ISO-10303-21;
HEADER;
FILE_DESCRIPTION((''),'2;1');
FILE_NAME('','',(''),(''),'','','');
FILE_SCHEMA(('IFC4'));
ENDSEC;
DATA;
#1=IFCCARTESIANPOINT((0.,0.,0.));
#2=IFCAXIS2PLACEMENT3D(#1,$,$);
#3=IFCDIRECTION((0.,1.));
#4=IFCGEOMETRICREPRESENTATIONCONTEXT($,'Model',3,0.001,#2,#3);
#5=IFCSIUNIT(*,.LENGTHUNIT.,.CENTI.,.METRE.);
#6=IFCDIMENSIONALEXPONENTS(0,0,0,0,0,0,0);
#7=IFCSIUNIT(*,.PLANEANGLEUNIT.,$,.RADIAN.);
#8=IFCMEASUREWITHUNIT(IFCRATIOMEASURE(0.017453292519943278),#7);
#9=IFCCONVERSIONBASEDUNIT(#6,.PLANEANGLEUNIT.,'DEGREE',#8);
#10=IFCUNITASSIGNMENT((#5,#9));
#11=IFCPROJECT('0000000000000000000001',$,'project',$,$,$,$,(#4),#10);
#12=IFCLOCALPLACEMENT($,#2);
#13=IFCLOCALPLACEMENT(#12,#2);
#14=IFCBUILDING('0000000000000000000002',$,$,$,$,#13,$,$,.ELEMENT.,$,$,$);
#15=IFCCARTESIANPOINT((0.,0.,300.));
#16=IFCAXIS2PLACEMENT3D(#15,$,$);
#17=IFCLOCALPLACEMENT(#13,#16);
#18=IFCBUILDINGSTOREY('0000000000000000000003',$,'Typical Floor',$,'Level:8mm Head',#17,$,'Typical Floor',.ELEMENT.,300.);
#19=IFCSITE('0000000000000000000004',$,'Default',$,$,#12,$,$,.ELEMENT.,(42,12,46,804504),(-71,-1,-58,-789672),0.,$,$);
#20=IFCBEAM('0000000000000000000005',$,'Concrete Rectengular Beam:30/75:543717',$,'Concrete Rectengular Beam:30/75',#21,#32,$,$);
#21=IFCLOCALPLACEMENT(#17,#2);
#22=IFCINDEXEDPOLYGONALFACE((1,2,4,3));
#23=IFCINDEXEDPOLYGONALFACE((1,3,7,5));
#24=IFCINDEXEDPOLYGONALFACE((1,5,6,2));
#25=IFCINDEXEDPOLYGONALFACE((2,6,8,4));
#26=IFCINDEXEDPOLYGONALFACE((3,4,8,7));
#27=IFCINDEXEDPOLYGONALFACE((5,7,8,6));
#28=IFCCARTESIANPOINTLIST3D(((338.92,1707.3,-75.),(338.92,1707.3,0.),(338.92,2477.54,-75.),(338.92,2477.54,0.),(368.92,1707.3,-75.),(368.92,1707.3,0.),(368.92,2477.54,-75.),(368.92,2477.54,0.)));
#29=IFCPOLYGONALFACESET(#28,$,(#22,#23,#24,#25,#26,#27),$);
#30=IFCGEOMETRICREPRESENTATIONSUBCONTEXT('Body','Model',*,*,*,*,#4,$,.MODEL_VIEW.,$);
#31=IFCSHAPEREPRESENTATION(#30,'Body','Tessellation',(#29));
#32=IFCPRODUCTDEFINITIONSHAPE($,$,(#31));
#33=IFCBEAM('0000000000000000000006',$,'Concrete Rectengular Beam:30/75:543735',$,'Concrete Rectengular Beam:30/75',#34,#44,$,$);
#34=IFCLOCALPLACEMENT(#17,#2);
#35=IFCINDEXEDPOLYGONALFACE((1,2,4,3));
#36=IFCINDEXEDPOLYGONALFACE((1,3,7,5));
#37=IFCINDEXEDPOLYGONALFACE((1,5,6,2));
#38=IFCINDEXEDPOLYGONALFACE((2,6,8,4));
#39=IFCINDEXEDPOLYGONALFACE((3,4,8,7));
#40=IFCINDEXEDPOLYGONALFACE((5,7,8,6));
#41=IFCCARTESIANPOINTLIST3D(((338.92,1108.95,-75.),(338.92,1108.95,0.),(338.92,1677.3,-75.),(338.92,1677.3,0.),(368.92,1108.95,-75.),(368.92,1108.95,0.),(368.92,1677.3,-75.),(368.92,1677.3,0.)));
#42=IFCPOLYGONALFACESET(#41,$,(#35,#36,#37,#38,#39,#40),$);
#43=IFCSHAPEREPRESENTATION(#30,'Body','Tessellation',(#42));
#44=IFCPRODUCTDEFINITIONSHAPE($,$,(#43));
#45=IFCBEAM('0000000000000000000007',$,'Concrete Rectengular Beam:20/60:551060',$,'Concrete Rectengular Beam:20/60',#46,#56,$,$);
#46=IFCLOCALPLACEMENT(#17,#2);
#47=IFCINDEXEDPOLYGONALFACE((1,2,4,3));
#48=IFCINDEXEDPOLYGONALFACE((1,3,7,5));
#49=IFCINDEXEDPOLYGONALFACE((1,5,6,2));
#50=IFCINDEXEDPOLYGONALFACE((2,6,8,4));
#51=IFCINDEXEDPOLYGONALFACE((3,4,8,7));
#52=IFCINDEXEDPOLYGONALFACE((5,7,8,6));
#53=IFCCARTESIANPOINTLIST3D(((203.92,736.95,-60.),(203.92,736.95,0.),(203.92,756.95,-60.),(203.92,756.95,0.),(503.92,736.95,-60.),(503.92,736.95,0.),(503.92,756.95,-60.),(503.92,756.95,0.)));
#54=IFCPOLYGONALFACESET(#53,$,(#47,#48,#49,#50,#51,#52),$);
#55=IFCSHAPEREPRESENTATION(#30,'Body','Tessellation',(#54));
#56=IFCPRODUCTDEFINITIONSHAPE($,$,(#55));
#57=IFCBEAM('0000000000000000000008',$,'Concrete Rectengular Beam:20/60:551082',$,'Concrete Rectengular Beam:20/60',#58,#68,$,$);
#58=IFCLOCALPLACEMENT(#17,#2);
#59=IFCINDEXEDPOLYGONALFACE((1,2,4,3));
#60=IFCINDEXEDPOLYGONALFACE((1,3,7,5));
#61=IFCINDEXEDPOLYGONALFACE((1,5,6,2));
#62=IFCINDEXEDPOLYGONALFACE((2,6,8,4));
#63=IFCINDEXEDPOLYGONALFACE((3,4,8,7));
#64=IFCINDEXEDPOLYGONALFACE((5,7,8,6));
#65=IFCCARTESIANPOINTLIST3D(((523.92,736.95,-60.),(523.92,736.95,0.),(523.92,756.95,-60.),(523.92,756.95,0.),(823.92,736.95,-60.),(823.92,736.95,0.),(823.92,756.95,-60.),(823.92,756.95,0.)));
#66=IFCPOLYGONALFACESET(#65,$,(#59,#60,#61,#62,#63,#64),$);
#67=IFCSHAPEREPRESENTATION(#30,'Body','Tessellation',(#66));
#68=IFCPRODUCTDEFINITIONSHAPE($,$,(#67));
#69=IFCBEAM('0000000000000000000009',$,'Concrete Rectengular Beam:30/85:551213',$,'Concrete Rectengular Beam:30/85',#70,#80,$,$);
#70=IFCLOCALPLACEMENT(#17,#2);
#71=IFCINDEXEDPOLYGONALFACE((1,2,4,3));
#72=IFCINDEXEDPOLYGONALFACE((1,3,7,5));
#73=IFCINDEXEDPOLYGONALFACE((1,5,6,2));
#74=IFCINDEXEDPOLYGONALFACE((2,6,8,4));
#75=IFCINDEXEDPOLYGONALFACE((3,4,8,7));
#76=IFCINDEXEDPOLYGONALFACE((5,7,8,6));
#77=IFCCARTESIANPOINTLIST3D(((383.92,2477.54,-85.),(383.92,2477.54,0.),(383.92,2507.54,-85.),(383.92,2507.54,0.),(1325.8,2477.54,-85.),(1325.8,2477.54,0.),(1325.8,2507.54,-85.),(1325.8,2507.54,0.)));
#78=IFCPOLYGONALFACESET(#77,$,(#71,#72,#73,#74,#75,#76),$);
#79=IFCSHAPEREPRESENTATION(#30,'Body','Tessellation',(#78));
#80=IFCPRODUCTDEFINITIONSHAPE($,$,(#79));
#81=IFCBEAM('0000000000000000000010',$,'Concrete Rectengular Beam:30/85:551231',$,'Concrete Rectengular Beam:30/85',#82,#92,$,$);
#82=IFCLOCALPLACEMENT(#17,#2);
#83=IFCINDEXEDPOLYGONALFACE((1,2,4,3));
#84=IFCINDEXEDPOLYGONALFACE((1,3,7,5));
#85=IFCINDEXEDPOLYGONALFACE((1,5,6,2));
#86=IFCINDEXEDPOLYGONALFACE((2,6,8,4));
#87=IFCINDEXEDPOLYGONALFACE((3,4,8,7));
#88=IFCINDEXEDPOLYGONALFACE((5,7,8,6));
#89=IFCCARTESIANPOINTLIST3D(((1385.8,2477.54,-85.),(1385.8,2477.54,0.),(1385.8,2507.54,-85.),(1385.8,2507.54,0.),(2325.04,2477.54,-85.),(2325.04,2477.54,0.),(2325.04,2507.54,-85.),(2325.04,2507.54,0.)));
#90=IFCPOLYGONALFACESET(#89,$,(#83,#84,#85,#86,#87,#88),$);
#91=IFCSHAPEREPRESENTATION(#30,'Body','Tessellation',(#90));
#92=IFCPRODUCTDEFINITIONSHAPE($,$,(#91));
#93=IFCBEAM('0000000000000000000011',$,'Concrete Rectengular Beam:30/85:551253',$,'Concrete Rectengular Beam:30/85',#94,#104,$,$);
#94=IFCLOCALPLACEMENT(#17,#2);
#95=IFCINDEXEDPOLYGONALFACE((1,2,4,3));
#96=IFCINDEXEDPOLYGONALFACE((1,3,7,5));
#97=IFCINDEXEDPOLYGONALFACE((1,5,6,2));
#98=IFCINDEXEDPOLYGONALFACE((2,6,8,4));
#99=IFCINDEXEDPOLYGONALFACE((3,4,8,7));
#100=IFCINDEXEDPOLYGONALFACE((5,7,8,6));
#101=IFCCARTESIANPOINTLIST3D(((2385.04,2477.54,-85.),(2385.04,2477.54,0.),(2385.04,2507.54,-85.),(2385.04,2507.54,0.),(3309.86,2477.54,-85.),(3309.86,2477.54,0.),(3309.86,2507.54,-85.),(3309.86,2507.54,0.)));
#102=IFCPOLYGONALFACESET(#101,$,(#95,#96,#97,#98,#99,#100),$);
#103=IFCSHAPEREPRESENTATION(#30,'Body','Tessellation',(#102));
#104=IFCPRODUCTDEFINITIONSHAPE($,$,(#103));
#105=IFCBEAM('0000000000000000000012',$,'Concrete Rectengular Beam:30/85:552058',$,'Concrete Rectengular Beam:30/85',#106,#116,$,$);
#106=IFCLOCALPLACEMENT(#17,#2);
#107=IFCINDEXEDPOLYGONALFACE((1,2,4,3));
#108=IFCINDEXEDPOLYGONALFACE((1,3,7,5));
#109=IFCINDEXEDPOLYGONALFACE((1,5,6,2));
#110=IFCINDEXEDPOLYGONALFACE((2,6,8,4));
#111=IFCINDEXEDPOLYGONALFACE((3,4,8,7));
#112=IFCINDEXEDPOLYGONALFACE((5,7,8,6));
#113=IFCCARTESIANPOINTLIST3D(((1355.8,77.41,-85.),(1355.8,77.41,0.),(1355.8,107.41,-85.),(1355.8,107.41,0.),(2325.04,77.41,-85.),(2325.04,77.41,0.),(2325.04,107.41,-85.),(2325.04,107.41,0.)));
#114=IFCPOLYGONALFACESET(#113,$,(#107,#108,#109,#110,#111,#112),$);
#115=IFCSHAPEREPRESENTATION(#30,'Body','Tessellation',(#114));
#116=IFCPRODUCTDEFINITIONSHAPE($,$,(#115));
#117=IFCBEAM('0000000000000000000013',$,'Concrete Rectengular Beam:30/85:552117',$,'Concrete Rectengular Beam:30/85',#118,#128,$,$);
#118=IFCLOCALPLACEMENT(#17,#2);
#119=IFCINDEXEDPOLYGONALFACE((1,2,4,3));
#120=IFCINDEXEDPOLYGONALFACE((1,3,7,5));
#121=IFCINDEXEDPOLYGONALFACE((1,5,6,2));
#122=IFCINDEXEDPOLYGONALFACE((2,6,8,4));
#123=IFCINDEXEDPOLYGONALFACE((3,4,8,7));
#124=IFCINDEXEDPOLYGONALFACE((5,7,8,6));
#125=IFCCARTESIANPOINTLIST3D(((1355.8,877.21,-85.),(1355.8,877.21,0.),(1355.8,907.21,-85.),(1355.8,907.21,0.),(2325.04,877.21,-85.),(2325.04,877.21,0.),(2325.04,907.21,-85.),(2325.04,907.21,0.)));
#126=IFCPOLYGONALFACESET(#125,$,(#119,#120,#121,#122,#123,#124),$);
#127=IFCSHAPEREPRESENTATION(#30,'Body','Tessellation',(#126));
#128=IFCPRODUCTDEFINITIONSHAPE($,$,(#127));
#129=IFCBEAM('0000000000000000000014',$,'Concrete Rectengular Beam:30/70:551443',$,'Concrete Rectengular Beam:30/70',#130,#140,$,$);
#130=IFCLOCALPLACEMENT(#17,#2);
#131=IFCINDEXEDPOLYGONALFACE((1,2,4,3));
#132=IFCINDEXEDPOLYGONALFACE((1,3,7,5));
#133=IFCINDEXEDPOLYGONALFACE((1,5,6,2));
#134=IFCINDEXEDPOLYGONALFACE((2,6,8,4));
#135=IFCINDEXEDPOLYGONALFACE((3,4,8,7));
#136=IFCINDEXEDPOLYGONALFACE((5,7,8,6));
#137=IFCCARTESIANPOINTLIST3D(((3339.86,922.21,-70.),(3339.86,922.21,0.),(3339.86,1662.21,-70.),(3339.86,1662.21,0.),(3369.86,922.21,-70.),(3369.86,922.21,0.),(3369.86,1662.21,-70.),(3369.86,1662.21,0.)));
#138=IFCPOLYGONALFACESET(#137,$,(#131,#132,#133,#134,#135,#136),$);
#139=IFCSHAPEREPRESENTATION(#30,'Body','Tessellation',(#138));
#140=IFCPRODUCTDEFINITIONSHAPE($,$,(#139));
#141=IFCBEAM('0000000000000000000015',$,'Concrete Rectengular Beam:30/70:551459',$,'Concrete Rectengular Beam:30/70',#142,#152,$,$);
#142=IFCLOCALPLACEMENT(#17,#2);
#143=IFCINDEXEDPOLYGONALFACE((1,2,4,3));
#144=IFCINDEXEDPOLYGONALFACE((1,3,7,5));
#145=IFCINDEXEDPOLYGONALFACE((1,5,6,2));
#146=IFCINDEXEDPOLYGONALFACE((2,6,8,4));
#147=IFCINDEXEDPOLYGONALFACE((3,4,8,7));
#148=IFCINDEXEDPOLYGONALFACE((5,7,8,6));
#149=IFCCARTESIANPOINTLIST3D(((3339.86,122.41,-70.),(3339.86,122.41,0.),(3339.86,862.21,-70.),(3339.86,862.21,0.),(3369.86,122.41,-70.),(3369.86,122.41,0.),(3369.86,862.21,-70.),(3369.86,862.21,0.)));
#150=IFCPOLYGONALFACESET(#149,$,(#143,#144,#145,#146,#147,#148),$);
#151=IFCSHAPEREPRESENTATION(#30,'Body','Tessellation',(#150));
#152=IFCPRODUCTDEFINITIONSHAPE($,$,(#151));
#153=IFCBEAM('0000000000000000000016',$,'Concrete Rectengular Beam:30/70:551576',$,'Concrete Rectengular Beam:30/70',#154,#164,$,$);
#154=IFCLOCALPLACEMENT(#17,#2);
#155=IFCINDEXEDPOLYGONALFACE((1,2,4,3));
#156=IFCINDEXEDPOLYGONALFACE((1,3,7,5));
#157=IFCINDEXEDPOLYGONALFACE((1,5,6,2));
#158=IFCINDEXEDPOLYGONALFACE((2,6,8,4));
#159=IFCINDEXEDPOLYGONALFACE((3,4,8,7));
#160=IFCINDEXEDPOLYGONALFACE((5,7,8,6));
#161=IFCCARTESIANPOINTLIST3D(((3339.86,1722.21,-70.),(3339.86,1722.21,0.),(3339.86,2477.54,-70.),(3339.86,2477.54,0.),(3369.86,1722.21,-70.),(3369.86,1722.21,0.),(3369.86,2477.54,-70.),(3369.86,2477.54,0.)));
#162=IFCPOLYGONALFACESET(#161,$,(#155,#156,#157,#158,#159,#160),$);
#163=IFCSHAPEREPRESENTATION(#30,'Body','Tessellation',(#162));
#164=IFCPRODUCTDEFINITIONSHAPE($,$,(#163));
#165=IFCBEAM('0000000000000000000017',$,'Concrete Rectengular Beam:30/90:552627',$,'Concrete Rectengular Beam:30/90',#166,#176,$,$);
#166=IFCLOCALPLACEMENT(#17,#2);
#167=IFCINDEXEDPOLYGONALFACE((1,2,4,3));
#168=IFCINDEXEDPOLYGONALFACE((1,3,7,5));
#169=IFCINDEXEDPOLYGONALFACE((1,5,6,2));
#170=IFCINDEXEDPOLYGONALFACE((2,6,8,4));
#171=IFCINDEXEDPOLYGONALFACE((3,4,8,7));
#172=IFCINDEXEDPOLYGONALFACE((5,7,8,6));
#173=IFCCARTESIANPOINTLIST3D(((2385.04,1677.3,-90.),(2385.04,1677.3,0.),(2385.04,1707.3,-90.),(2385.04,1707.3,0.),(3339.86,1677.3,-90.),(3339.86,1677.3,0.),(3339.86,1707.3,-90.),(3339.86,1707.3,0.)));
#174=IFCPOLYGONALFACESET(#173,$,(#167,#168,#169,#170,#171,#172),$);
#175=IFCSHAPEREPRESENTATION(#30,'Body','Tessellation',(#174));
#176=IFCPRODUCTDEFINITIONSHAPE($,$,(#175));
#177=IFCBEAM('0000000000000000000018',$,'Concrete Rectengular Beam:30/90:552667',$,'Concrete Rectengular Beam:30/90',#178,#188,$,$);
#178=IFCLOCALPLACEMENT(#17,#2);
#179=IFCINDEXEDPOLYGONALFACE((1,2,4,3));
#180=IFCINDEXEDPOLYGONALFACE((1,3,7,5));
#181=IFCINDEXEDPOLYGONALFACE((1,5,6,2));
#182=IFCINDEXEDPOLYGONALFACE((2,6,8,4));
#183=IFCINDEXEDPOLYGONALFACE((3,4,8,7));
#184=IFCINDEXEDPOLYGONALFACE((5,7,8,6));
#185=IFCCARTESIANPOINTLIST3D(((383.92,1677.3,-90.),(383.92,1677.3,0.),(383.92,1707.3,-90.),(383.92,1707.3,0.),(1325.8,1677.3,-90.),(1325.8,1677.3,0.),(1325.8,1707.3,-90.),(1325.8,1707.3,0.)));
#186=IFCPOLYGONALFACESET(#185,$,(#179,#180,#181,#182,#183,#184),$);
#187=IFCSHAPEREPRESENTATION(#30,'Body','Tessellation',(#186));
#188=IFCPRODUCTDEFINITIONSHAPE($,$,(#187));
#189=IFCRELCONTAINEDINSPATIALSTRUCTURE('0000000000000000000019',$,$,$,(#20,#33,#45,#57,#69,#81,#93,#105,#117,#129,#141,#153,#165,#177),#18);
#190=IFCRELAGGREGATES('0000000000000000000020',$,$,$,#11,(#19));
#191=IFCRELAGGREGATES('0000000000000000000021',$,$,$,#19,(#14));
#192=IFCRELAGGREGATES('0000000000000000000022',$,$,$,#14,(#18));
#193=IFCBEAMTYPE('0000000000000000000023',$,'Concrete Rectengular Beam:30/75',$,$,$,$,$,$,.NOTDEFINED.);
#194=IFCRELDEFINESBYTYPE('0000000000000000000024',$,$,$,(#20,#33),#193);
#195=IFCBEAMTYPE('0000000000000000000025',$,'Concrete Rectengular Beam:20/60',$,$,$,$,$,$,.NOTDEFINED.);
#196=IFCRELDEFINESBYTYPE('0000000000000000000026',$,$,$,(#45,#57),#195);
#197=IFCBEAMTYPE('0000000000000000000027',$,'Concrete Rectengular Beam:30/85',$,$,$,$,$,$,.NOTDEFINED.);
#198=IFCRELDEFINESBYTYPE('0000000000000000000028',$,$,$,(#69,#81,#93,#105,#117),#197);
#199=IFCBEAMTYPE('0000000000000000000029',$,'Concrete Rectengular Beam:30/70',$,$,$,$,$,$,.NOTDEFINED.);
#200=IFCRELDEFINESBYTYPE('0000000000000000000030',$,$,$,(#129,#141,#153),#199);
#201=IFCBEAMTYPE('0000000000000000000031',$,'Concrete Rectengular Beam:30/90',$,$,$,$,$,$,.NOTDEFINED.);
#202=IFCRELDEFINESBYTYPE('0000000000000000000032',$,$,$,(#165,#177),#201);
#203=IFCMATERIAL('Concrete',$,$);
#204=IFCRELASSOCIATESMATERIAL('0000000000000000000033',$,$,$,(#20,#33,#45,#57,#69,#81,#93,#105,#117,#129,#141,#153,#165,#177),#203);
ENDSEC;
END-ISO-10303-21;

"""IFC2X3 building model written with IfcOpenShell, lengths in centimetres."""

from ifc_helpers import new_model, entity, si_unit, converted_unit, direction, frame, frame_2d, origin, place, context, subcontext, project, spatial, rectangle, extrude, material, type_object, element, save


model = new_model("IFC2X3")

# Units and contexts
model_context = context("Model", 3, precision=0.001, world=origin(), true_north=direction((0.0, 1.0)))
body_context = subcontext(model_context, "Body", "Model", "MODEL_VIEW")
ifc_project = project(units=[si_unit("LENGTHUNIT", "METRE", prefix="CENTI"), converted_unit("PLANEANGLEUNIT", "DEGREE", entity("IfcRatioMeasure", 0.017453292519943278), si_unit("PLANEANGLEUNIT", "RADIAN"), dimensions=[0, 0, 0, 0, 0, 0, 0])], contexts=[model_context])

# Site, building, storey
site_placement = place(None, origin())
site = spatial("IfcSite", under=ifc_project, at=site_placement, Name="Default", CompositionType="ELEMENT", RefLatitude=(42, 12, 46, 804504), RefLongitude=(-71, -1, -58, -789672), RefElevation=0.0)
building_placement = place(site_placement, origin())
building = spatial("IfcBuilding", under=site, at=building_placement, CompositionType="ELEMENT")
storey_placement = place(building_placement, frame((0.0, 0.0, 300.0)))
storey = spatial("IfcBuildingStorey", under=building, at=storey_placement, Name="Typical Floor", ObjectType="Level:8mm Head", LongName="Typical Floor", CompositionType="ELEMENT", Elevation=300.0)

# Beams
ifc_material = material(Name="Concrete")
beam_type_1 = type_object("IfcBeamType", Name="Concrete Rectengular Beam:30/75", PredefinedType="NOTDEFINED")
beam_1_placement = place(storey_placement, frame((353.92, 2492.54, 0.0), z_axis=(0.0, 0.0, 1.0), x_axis=(0.0, -1.0, 0.0)))
element("IfcBeam", 1, at=beam_1_placement, inside=storey, type_object=beam_type_1, material=ifc_material, Name="Concrete Rectengular Beam:30/75:543717", ObjectType="Concrete Rectengular Beam:30/75", context=body_context, shape_type="SweptSolid", body=[
    extrude(rectangle(XDim=75.0, YDim=30.0, at=frame_2d((0.0, 0.0), x_axis=(1.0, 0.0))), frame((15.0, 0.0, -37.5), z_axis=(1.0, 0.0, 0.0), x_axis=(0.0, 0.0, -1.0)), (0.0, 0.0, 1.0), 770.24),
])
beam_2_placement = place(storey_placement, frame((353.92, 1692.3, 0.0), z_axis=(0.0, 0.0, 1.0), x_axis=(0.0, -1.0, 0.0)))
element("IfcBeam", 2, at=beam_2_placement, inside=storey, type_object=beam_type_1, material=ifc_material, Name="Concrete Rectengular Beam:30/75:543735", ObjectType="Concrete Rectengular Beam:30/75", context=body_context, shape_type="SweptSolid", body=[
    extrude(rectangle(XDim=75.0, YDim=30.0, at=frame_2d((0.0, 0.0), x_axis=(1.0, 0.0))), frame((15.0, 0.0, -37.5), z_axis=(1.0, 0.0, 0.0), x_axis=(0.0, 0.0, -1.0)), (0.0, 0.0, 1.0), 568.35),
])
beam_type_2 = type_object("IfcBeamType", Name="Concrete Rectengular Beam:20/60", PredefinedType="NOTDEFINED")
for number, where, name in (
    (3, (193.92, 746.95, 0.0), "Concrete Rectengular Beam:20/60:551060"),
    (4, (513.92, 746.95, 0.0), "Concrete Rectengular Beam:20/60:551082"),
):
    element("IfcBeam", number, at=place(storey_placement, frame(where)), inside=storey, type_object=beam_type_2, material=ifc_material, Name=name, ObjectType="Concrete Rectengular Beam:20/60", context=body_context, shape_type="SweptSolid", body=[
        extrude(rectangle(XDim=60.0, YDim=20.0, at=frame_2d((0.0, 0.0), x_axis=(1.0, 0.0))), frame((10.0, 0.0, -30.0), z_axis=(1.0, 0.0, 0.0), x_axis=(0.0, 0.0, -1.0)), (0.0, 0.0, 1.0), 300.0),
    ])
beam_type_3 = type_object("IfcBeamType", Name="Concrete Rectengular Beam:30/85", PredefinedType="NOTDEFINED")
beam_3_placement = place(storey_placement, frame((353.92, 2492.54, 0.0)))
element("IfcBeam", 5, at=beam_3_placement, inside=storey, type_object=beam_type_3, material=ifc_material, Name="Concrete Rectengular Beam:30/85:551213", ObjectType="Concrete Rectengular Beam:30/85", context=body_context, shape_type="SweptSolid", body=[
    extrude(rectangle(XDim=85.0, YDim=30.0, at=frame_2d((0.0, 0.0), x_axis=(1.0, 0.0))), frame((30.0, 0.0, -42.5), z_axis=(1.0, 0.0, 0.0), x_axis=(0.0, 0.0, -1.0)), (0.0, 0.0, 1.0), 941.88),
])
beam_4_placement = place(storey_placement, frame((1355.8, 2492.54, 0.0)))
element("IfcBeam", 6, at=beam_4_placement, inside=storey, type_object=beam_type_3, material=ifc_material, Name="Concrete Rectengular Beam:30/85:551231", ObjectType="Concrete Rectengular Beam:30/85", context=body_context, shape_type="SweptSolid", body=[
    extrude(rectangle(XDim=85.0, YDim=30.0, at=frame_2d((0.0, 0.0), x_axis=(1.0, 0.0))), frame((30.0, 0.0, -42.5), z_axis=(1.0, 0.0, 0.0), x_axis=(0.0, 0.0, -1.0)), (0.0, 0.0, 1.0), 939.24),
])
beam_5_placement = place(storey_placement, frame((2355.04, 2492.54, 0.0)))
element("IfcBeam", 7, at=beam_5_placement, inside=storey, type_object=beam_type_3, material=ifc_material, Name="Concrete Rectengular Beam:30/85:551253", ObjectType="Concrete Rectengular Beam:30/85", context=body_context, shape_type="SweptSolid", body=[
    extrude(rectangle(XDim=85.0, YDim=30.0, at=frame_2d((0.0, 0.0), x_axis=(1.0, 0.0))), frame((30.0, 0.0, -42.5), z_axis=(1.0, 0.0, 0.0), x_axis=(0.0, 0.0, -1.0)), (0.0, 0.0, 1.0), 924.83),
])
beam_6_placement = place(storey_placement, frame((2355.04, 92.41, 0.0), z_axis=(0.0, 0.0, 1.0), x_axis=(-1.0, 0.0, 0.0)))
element("IfcBeam", 8, at=beam_6_placement, inside=storey, type_object=beam_type_3, material=ifc_material, Name="Concrete Rectengular Beam:30/85:552058", ObjectType="Concrete Rectengular Beam:30/85", context=body_context, shape_type="SweptSolid", body=[
    extrude(rectangle(XDim=85.0, YDim=30.0, at=frame_2d((0.0, 0.0), x_axis=(1.0, 0.0))), frame((30.0, 0.0, -42.5), z_axis=(1.0, 0.0, 0.0), x_axis=(0.0, 0.0, -1.0)), (0.0, 0.0, 1.0), 969.24),
])
beam_7_placement = place(storey_placement, frame((2355.04, 892.21, 0.0), z_axis=(0.0, 0.0, 1.0), x_axis=(-1.0, 0.0, 0.0)))
element("IfcBeam", 9, at=beam_7_placement, inside=storey, type_object=beam_type_3, material=ifc_material, Name="Concrete Rectengular Beam:30/85:552117", ObjectType="Concrete Rectengular Beam:30/85", context=body_context, shape_type="SweptSolid", body=[
    extrude(rectangle(XDim=85.0, YDim=30.0, at=frame_2d((0.0, 0.0), x_axis=(1.0, 0.0))), frame((30.0, 0.0, -42.5), z_axis=(1.0, 0.0, 0.0), x_axis=(0.0, 0.0, -1.0)), (0.0, 0.0, 1.0), 969.24),
])
beam_type_4 = type_object("IfcBeamType", Name="Concrete Rectengular Beam:30/70", PredefinedType="NOTDEFINED")
beam_8_placement = place(storey_placement, frame((3369.86, 1692.21, 0.0), z_axis=(0.0, 0.0, 1.0), x_axis=(0.0, -1.0, 0.0)))
element("IfcBeam", 10, at=beam_8_placement, inside=storey, type_object=beam_type_4, material=ifc_material, Name="Concrete Rectengular Beam:30/70:551443", ObjectType="Concrete Rectengular Beam:30/70", context=body_context, shape_type="SweptSolid", body=[
    extrude(rectangle(XDim=70.0, YDim=30.0, at=frame_2d((0.0, 0.0), x_axis=(1.0, 0.0))), frame((30.0, -15.0, -35.0), z_axis=(1.0, 0.0, 0.0), x_axis=(0.0, 0.0, -1.0)), (0.0, 0.0, 1.0), 740.0),
])
beam_9_placement = place(storey_placement, frame((3369.86, 892.21, 0.0), z_axis=(0.0, 0.0, 1.0), x_axis=(0.0, -1.0, 0.0)))
element("IfcBeam", 11, at=beam_9_placement, inside=storey, type_object=beam_type_4, material=ifc_material, Name="Concrete Rectengular Beam:30/70:551459", ObjectType="Concrete Rectengular Beam:30/70", context=body_context, shape_type="SweptSolid", body=[
    extrude(rectangle(XDim=70.0, YDim=30.0, at=frame_2d((0.0, 0.0), x_axis=(1.0, 0.0))), frame((30.0, -15.0, -35.0), z_axis=(1.0, 0.0, 0.0), x_axis=(0.0, 0.0, -1.0)), (0.0, 0.0, 1.0), 739.8),
])
beam_10_placement = place(storey_placement, frame((3369.86, 2492.54, 0.0), z_axis=(0.0, 0.0, 1.0), x_axis=(0.0, -1.0, 0.0)))
element("IfcBeam", 12, at=beam_10_placement, inside=storey, type_object=beam_type_4, material=ifc_material, Name="Concrete Rectengular Beam:30/70:551576", ObjectType="Concrete Rectengular Beam:30/70", context=body_context, shape_type="SweptSolid", body=[
    extrude(rectangle(XDim=70.0, YDim=30.0, at=frame_2d((0.0, 0.0), x_axis=(1.0, 0.0))), frame((15.0, -15.0, -35.0), z_axis=(1.0, 0.0, 0.0), x_axis=(0.0, 0.0, -1.0)), (0.0, 0.0, 1.0), 755.33),
])
beam_type_5 = type_object("IfcBeamType", Name="Concrete Rectengular Beam:30/90", PredefinedType="NOTDEFINED")
beam_11_placement = place(storey_placement, frame((3354.86, 1692.3, 0.0), z_axis=(0.0, 0.0, 1.0), x_axis=(-1.0, 0.0, 0.0)))
element("IfcBeam", 13, at=beam_11_placement, inside=storey, type_object=beam_type_5, material=ifc_material, Name="Concrete Rectengular Beam:30/90:552627", ObjectType="Concrete Rectengular Beam:30/90", context=body_context, shape_type="SweptSolid", body=[
    extrude(rectangle(XDim=90.0, YDim=30.0, at=frame_2d((0.0, 0.0), x_axis=(1.0, 0.0))), frame((15.0, 0.0, -45.0), z_axis=(1.0, 0.0, 0.0), x_axis=(0.0, 0.0, -1.0)), (0.0, 0.0, 1.0), 954.83),
])
beam_12_placement = place(storey_placement, frame((1355.8, 1692.3, 0.0), z_axis=(0.0, 0.0, 1.0), x_axis=(-1.0, 0.0, 0.0)))
element("IfcBeam", 14, at=beam_12_placement, inside=storey, type_object=beam_type_5, material=ifc_material, Name="Concrete Rectengular Beam:30/90:552667", ObjectType="Concrete Rectengular Beam:30/90", context=body_context, shape_type="SweptSolid", body=[
    extrude(rectangle(XDim=90.0, YDim=30.0, at=frame_2d((0.0, 0.0), x_axis=(1.0, 0.0))), frame((30.0, 0.0, -45.0), z_axis=(1.0, 0.0, 0.0), x_axis=(0.0, 0.0, -1.0)), (0.0, 0.0, 1.0), 941.88),
])

save(model, "model.ifc")
